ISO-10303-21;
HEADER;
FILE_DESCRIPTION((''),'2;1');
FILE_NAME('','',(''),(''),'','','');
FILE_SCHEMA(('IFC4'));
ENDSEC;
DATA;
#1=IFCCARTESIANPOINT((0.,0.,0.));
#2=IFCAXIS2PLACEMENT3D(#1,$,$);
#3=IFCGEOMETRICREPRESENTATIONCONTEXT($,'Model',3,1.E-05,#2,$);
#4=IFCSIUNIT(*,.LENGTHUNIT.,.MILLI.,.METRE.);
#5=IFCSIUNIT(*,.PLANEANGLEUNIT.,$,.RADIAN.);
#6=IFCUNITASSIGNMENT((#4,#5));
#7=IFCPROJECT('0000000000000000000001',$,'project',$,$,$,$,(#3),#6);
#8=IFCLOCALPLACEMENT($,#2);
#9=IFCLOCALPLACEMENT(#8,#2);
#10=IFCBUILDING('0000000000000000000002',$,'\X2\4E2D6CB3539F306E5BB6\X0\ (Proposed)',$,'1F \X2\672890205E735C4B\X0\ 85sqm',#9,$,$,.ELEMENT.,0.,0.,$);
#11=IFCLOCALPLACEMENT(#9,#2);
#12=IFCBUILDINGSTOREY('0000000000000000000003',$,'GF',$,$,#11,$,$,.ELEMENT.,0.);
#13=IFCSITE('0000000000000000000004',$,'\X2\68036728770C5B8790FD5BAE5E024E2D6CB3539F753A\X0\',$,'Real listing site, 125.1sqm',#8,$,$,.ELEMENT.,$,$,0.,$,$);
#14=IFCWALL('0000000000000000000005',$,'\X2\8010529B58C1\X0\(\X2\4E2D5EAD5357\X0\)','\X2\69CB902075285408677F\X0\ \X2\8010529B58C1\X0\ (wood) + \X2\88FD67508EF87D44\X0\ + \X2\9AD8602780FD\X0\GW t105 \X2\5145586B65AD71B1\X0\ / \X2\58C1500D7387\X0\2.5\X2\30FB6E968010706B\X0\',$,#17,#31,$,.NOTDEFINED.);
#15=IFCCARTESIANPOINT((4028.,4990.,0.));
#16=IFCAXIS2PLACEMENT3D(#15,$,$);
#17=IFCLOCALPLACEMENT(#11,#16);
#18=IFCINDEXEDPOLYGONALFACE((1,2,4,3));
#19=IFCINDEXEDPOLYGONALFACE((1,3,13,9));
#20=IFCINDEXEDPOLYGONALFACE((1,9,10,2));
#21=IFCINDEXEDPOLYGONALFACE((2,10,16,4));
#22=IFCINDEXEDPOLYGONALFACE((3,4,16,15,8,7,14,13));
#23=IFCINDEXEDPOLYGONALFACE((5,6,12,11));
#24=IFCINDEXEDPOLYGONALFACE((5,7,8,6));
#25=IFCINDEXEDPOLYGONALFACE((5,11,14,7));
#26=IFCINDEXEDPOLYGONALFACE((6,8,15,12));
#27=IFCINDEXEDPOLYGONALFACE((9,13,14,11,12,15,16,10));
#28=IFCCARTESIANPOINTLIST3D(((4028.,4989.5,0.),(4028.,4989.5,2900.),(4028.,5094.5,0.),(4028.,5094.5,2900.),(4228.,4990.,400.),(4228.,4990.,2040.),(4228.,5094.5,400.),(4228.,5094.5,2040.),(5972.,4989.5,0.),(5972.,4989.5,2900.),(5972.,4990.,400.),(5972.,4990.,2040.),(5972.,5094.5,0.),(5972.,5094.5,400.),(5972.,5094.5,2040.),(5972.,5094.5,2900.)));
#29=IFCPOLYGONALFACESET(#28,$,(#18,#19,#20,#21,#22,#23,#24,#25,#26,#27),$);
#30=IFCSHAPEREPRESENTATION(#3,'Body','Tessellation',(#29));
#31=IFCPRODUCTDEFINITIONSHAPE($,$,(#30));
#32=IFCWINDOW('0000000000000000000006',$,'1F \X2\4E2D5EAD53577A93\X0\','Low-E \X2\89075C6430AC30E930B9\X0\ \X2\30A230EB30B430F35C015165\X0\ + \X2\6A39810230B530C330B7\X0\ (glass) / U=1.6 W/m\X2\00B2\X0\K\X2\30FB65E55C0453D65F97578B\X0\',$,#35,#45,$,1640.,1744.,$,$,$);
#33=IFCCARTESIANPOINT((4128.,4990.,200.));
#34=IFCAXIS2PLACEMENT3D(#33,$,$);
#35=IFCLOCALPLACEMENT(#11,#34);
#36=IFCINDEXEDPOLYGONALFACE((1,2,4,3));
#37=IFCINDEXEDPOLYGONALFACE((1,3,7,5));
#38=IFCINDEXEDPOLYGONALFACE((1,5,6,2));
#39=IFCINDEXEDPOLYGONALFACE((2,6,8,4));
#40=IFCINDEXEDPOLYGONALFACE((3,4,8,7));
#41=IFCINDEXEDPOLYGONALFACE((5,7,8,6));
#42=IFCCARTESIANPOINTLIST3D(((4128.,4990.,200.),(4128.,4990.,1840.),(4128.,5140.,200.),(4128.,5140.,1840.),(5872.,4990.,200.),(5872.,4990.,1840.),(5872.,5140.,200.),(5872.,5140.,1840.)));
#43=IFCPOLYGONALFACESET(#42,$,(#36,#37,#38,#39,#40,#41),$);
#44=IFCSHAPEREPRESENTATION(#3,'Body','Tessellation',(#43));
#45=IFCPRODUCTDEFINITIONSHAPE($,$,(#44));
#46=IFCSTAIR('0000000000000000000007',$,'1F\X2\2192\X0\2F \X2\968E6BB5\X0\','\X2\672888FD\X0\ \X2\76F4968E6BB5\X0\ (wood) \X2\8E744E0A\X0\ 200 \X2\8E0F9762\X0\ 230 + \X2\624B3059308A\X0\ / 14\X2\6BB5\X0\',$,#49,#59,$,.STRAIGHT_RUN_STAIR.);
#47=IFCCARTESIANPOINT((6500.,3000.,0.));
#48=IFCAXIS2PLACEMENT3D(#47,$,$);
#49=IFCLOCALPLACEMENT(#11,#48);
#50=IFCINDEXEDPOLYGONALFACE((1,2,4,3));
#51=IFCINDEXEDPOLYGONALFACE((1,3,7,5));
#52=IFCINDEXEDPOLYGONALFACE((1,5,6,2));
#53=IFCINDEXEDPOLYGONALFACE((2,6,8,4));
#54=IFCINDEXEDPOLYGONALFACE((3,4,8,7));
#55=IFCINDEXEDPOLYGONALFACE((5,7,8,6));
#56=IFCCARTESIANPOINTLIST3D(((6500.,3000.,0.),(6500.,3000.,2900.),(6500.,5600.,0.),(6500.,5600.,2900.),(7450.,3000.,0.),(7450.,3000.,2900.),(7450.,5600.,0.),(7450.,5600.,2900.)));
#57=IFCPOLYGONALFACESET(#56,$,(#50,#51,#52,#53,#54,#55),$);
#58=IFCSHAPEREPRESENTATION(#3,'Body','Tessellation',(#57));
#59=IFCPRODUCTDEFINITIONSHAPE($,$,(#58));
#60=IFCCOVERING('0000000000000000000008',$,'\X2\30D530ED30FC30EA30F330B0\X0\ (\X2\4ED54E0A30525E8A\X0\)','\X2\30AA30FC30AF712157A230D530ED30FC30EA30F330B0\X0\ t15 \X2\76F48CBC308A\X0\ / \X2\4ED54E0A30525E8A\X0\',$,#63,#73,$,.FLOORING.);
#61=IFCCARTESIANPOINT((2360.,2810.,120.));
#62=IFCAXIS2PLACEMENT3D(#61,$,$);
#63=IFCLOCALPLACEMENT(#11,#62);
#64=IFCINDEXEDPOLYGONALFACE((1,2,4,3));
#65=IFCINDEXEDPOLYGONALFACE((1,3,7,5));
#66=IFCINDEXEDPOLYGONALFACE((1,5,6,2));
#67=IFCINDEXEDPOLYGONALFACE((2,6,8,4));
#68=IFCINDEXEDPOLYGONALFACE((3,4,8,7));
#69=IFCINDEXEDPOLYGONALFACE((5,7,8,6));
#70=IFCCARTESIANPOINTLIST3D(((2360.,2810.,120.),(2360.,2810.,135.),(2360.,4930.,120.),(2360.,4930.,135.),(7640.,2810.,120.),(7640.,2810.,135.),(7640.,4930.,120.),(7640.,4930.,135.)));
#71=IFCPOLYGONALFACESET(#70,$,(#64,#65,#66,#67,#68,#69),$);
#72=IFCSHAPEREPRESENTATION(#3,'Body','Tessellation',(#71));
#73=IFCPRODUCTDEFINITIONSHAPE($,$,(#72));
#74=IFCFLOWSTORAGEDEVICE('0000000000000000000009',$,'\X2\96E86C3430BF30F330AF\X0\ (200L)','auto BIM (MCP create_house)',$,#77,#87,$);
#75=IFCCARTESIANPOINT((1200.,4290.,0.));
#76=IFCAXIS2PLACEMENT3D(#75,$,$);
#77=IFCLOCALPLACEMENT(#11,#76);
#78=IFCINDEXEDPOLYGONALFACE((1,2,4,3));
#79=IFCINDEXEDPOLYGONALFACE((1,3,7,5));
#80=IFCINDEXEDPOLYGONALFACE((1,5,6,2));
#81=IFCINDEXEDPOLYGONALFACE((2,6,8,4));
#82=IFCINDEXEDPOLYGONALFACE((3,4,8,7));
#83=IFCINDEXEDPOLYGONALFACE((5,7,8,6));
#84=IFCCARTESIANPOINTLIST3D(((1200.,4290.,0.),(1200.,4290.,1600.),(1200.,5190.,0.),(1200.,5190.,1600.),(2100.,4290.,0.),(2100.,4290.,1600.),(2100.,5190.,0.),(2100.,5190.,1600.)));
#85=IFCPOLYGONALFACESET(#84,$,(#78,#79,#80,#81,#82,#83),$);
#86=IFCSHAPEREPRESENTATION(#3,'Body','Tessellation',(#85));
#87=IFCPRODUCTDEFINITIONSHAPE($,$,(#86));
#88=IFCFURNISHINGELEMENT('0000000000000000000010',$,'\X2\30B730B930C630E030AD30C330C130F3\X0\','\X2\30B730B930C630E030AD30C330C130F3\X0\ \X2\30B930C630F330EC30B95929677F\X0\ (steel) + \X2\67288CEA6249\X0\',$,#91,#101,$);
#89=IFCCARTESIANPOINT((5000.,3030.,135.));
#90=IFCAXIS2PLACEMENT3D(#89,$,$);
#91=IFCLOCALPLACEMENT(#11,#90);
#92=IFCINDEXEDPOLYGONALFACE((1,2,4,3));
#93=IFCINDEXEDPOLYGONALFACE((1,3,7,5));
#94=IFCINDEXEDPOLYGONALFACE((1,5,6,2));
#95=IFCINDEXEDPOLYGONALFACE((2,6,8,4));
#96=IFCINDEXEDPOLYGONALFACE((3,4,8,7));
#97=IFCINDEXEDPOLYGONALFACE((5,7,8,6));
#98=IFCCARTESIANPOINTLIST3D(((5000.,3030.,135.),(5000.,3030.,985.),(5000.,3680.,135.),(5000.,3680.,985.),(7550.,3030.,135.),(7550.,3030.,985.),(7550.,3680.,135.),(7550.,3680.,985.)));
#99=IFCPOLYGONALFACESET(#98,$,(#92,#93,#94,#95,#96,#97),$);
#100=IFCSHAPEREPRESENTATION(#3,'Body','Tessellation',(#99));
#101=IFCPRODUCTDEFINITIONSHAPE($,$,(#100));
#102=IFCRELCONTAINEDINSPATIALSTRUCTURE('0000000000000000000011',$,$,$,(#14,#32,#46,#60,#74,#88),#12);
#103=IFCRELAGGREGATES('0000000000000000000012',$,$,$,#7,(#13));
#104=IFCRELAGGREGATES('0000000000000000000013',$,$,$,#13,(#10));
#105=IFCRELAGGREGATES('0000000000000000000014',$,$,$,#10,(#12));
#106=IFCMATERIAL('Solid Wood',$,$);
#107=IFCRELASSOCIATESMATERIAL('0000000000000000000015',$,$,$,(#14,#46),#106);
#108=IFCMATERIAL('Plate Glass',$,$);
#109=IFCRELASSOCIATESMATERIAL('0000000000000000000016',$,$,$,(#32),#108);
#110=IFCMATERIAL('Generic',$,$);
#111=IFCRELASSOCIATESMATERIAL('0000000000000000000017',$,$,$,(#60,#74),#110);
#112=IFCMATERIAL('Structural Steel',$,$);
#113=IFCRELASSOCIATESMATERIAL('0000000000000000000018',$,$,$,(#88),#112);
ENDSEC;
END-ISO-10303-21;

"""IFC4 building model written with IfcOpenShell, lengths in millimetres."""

from ifc_helpers import new_model, si_unit, frame, frame_2d, origin, place, context, project, spatial, rectangle, extrude, material, element, fill, save


model = new_model("IFC4")

# Units and contexts
model_context = context("Model", 3, precision=1e-05, world=origin())
ifc_project = project(units=[si_unit("LENGTHUNIT", "METRE", prefix="MILLI"), si_unit("PLANEANGLEUNIT", "RADIAN")], contexts=[model_context])

# Site, building, storey
site_placement = place(None, origin())
site = spatial("IfcSite", under=ifc_project, at=site_placement, Name="栃木県宇都宮市中河原町", ObjectType="Real listing site, 125.1sqm", CompositionType="ELEMENT", RefElevation=0.0)
building_placement = place(site_placement, origin())
building = spatial("IfcBuilding", under=site, at=building_placement, Name="中河原の家 (Proposed)", ObjectType="1F 木造平屋 85sqm", CompositionType="ELEMENT", ElevationOfRefHeight=0.0, ElevationOfTerrain=0.0)
storey_placement = place(building_placement, origin())
storey = spatial("IfcBuildingStorey", under=building, at=storey_placement, Name="GF", CompositionType="ELEMENT", Elevation=0.0)

# Shared definitions
ifc_material_1 = material(Name="Solid Wood")
ifc_material_2 = material(Name="Generic")

# Shared definitions
ifc_material_3 = material(Name="Plate Glass")

# Wall, opening, window
wall_1_placement = place(storey_placement, frame((4028.0, 4990.0, 0.0)))
wall_1 = element("IfcWall", 1, at=wall_1_placement, inside=storey, material=ifc_material_1, Name="耐力壁(中庭南)", Description="構造用合板 耐力壁 (wood) + 製材軸組 + 高性能GW t105 充填断熱 / 壁倍率2.5・準耐火", PredefinedType="NOTDEFINED", context=model_context, shape_type="SweptSolid", body=[
    extrude(rectangle(XDim=1944.0, YDim=105.0, at=frame_2d((972.0, 52.0))), frame((4028.0, 4990.0, 0.0)), (0.0, 0.0, 1.0), 2900.0),
])
opening_1_placement = place(storey_placement, frame((4128.0, 4990.0, 200.0)))
opening_1 = element("IfcOpeningElement", 2, at=opening_1_placement, cuts=wall_1, PredefinedType="NOTDEFINED", context=model_context, shape_type="SweptSolid", body=[
    extrude(rectangle(XDim=1744.0, YDim=150.0, at=frame_2d((872.0, 75.0))), frame((4128.0, 4990.0, 200.0)), (0.0, 0.0, 1.0), 1640.0),
])
window_1_placement = place(storey_placement, frame((4128.0, 4990.0, 200.0)))
window_1 = element("IfcWindow", 3, at=window_1_placement, inside=storey, material=ifc_material_3, Name="1F 中庭南窓", Description="Low-E 複層ガラス アルゴン封入 + 樹脂サッシ (glass) / U=1.6 W/m²K・日射取得型", OverallHeight=1640.0, OverallWidth=1744.0, context=model_context, shape_type="SweptSolid", body=[
    extrude(rectangle(XDim=1744.0, YDim=150.0, at=frame_2d((872.0, 75.0))), frame((4128.0, 4990.0, 200.0)), (0.0, 0.0, 1.0), 1640.0),
])
fill(opening_1, window_1)

# Stair
stair_placement = place(storey_placement, frame((6500.0, 3000.0, 0.0)))
element("IfcStair", 4, at=stair_placement, inside=storey, material=ifc_material_1, Name="1F→2F 階段", Description="木製 直階段 (wood) 蹴上 200 踏面 230 + 手すり / 14段", PredefinedType="STRAIGHT_RUN_STAIR", context=model_context, shape_type="SweptSolid", body=[
    extrude(rectangle(XDim=950.0, YDim=2600.0, at=frame_2d((475.0, 1300.0))), frame((6500.0, 3000.0, 0.0)), (0.0, 0.0, 1.0), 2900.0),
])

# Covering
covering_placement = place(storey_placement, frame((2360.0, 2810.0, 120.0)))
element("IfcCovering", 5, at=covering_placement, inside=storey, material=ifc_material_2, Name="フローリング (仕上げ床)", Description="オーク無垢フローリング t15 直貼り / 仕上げ床", PredefinedType="FLOORING", context=model_context, shape_type="SweptSolid", body=[
    extrude(rectangle(XDim=5280.0, YDim=2120.0, at=frame_2d((2640.0, 1060.0))), frame((2360.0, 2810.0, 120.0)), (0.0, 0.0, 1.0), 15.0),
])

# Flow storage device
flow_storage_device_placement = place(storey_placement, frame((1200.0, 4290.0, 0.0)))
element("IfcFlowStorageDevice", 6, at=flow_storage_device_placement, inside=storey, material=ifc_material_2, Name="雨水タンク (200L)", Description="auto BIM (MCP create_house)", context=model_context, shape_type="SweptSolid", body=[
    extrude(rectangle(XDim=900.0, YDim=900.0, at=frame_2d((450.0, 450.0))), frame((1200.0, 4290.0, 0.0)), (0.0, 0.0, 1.0), 1600.0),
])

# Furnishing element
ifc_material_4 = material(Name="Structural Steel")
furnishing_placement = place(storey_placement, frame((5000.0, 3030.0, 135.0)))
element("IfcFurnishingElement", 7, at=furnishing_placement, inside=storey, material=ifc_material_4, Name="システムキッチン", Description="システムキッチン ステンレス天板 (steel) + 木質扉", context=model_context, shape_type="SweptSolid", body=[
    extrude(rectangle(XDim=2550.0, YDim=650.0, at=frame_2d((1275.0, 325.0))), frame((5000.0, 3030.0, 135.0)), (0.0, 0.0, 1.0), 850.0),
])

save(model, "model.ifc")
